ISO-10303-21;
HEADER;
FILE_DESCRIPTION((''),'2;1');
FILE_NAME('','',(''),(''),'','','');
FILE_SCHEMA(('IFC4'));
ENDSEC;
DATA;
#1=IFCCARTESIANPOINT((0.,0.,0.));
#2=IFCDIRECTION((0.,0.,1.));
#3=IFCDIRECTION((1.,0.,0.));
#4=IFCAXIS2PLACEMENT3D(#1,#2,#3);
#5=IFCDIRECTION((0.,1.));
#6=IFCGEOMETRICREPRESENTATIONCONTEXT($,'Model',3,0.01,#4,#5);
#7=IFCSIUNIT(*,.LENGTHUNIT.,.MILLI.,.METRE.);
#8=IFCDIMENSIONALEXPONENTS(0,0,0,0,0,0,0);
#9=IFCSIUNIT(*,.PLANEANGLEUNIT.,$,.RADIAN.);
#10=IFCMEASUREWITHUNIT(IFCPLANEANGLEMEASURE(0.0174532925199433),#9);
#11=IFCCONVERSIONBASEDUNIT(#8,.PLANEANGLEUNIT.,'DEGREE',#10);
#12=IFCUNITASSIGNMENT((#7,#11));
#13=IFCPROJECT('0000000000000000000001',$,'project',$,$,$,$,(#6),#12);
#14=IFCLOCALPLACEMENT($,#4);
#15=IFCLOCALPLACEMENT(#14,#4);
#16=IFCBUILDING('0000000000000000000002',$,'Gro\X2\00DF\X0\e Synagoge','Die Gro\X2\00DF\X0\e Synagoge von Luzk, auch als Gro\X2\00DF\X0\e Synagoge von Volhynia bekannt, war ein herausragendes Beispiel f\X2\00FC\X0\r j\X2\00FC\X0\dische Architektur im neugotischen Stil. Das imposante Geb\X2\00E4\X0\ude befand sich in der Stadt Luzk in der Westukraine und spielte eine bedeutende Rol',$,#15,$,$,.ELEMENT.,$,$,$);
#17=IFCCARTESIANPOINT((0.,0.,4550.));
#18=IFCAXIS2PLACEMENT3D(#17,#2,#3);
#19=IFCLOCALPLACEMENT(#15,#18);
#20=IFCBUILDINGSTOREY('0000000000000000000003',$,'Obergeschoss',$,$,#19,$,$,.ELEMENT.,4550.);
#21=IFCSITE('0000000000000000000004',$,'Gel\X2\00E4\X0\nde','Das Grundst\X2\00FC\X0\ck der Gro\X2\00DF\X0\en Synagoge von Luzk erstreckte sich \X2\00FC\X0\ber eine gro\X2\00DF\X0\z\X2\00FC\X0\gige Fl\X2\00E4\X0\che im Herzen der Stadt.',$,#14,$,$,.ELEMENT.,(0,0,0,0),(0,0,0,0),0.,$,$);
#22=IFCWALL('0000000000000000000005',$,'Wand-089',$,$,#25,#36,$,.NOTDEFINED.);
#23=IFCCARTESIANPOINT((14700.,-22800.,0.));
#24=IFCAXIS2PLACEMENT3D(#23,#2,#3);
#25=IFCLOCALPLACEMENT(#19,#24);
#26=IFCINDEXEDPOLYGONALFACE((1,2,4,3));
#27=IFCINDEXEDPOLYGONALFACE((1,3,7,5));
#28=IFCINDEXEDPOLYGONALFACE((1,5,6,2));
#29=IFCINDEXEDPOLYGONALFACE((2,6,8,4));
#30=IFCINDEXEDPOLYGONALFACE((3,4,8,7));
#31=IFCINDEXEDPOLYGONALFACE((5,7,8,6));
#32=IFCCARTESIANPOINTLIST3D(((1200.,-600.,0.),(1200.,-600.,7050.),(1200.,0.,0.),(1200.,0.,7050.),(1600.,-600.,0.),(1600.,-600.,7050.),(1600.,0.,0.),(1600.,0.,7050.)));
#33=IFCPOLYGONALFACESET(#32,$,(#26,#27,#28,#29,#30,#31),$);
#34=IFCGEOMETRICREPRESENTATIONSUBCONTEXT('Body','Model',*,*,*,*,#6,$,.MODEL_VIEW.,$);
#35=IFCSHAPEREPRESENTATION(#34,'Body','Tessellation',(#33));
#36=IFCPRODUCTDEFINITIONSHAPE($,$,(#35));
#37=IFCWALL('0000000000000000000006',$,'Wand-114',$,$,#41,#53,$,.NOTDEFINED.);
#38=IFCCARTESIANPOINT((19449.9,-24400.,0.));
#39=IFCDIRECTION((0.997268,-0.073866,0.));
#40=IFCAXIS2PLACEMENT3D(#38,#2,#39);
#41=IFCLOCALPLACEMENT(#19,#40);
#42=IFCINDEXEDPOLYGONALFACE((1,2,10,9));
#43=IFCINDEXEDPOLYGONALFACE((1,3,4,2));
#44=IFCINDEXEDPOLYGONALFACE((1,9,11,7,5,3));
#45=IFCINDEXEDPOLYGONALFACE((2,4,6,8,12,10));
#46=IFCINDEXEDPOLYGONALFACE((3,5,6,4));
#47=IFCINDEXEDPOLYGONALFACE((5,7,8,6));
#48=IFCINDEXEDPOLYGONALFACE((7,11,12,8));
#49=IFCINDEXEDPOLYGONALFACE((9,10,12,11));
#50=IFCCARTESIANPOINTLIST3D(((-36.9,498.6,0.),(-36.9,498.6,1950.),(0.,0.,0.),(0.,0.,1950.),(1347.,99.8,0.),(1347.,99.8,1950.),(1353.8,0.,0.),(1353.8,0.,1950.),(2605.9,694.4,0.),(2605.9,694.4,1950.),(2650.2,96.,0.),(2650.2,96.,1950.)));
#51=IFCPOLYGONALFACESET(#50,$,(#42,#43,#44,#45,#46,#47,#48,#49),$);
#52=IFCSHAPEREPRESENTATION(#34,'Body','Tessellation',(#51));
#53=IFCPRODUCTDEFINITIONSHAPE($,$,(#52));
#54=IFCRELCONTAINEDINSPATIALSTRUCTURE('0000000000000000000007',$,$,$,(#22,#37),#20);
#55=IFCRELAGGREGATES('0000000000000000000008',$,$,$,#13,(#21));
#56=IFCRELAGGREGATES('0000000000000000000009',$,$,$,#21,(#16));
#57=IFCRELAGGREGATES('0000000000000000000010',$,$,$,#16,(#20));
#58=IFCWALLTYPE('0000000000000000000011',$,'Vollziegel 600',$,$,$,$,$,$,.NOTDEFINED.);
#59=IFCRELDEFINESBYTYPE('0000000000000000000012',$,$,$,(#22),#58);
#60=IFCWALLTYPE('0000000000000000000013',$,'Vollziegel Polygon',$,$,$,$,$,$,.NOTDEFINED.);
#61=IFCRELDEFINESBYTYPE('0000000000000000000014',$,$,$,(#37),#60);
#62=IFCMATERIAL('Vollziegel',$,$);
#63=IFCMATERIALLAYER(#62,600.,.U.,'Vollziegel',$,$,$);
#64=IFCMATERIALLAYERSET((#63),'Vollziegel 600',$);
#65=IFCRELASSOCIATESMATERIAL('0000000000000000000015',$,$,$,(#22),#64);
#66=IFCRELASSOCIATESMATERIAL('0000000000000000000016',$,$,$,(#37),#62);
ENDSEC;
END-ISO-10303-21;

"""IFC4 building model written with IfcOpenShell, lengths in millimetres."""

from ifc_helpers import new_model, entity, si_unit, converted_unit, direction, frame, origin_with_axes, place, context, subcontext, project, spatial, line, indexed_curve, outline, extrude, material, layer, layer_set, layer_usage, type_object, element, save


model = new_model("IFC4")

# Units and contexts
model_context = context("Model", 3, precision=0.01, world=origin_with_axes(), true_north=direction((0.0, 1.0)))
body_context = subcontext(model_context, "Body", "Model", "MODEL_VIEW")
ifc_project = project(units=[si_unit("LENGTHUNIT", "METRE", prefix="MILLI"), converted_unit("PLANEANGLEUNIT", "DEGREE", entity("IfcPlaneAngleMeasure", 0.0174532925199433), si_unit("PLANEANGLEUNIT", "RADIAN"), dimensions=[0, 0, 0, 0, 0, 0, 0])], contexts=[model_context])

# Site, building, storey
site_placement = place(None, origin_with_axes())
site = spatial("IfcSite", under=ifc_project, at=site_placement, Name="Gelände", Description="Das Grundstück der Großen Synagoge von Luzk erstreckte sich über eine großzügige Fläche im Herzen der Stadt.", CompositionType="ELEMENT", RefLatitude=(0, 0, 0, 0), RefLongitude=(0, 0, 0, 0), RefElevation=0.0)
building_placement = place(site_placement, origin_with_axes())
building = spatial("IfcBuilding", under=site, at=building_placement, Name="Große Synagoge", Description="Die Große Synagoge von Luzk, auch als Große Synagoge von Volhynia bekannt, war ein herausragendes Beispiel für jüdische Architektur im neugotischen Stil. Das imposante Gebäude befand sich in der Stadt Luzk in der Westukraine und spielte eine bedeutende Rol", CompositionType="ELEMENT")
storey_placement = place(building_placement, frame((0.0, 0.0, 4550.0), z_axis=(0.0, 0.0, 1.0), x_axis=(1.0, 0.0, 0.0)))
storey = spatial("IfcBuildingStorey", under=building, at=storey_placement, Name="Obergeschoss", CompositionType="ELEMENT", Elevation=4550.0)

# Shared definitions
ifc_material_1 = material(Name="Vollziegel")

# Walls
ifc_layer_1 = layer(ifc_material_1, 600.0, ventilated="UNKNOWN", Name="Vollziegel")
ifc_layer_set_1 = layer_set([ifc_layer_1], Name="Vollziegel 600")
ifc_layer_usage_1 = layer_usage(ifc_layer_set_1, "AXIS2", "POSITIVE", -600.0)
wall_type_1 = type_object("IfcWallType", Name="Vollziegel 600", PredefinedType="NOTDEFINED")
wall_1_placement = place(storey_placement, frame((14700.0, -22800.0, 0.0), z_axis=(0.0, 0.0, 1.0), x_axis=(1.0, 0.0, 0.0)))
element("IfcWall", 1, at=wall_1_placement, inside=storey, type_object=wall_type_1, material=ifc_layer_usage_1, Name="Wand-089", PredefinedType="NOTDEFINED", context=body_context, shape_type="SweptSolid", body=[
    extrude(outline(indexed_curve([(1200.0, -600.0), (1600.0, -600.0), (1600.0, 0.0), (1200.0, 0.0)], segments=[line(1, 2, 3, 4, 1)])), origin_with_axes(), (0.0, 0.0, 1.0), 7050.0),
])
wall_type_2 = type_object("IfcWallType", Name="Vollziegel Polygon", PredefinedType="NOTDEFINED")
wall_2_placement = place(storey_placement, frame((19449.9, -24400.0, 0.0), z_axis=(0.0, 0.0, 1.0), x_axis=(0.997268, -0.073866, 0.0)))
element("IfcWall", 2, at=wall_2_placement, inside=storey, type_object=wall_type_2, material=ifc_material_1, Name="Wand-114", PredefinedType="NOTDEFINED", context=body_context, shape_type="SweptSolid", body=[
    extrude(outline(indexed_curve([(0.0, 0.0), (1347.0, 99.8), (1353.8, 0.0), (2650.2, 96.0), (2605.9, 694.4), (-36.9, 498.6)], segments=[line(1, 2, 3, 4, 5, 6, 1)])), origin_with_axes(), (0.0, 0.0, 1.0), 1950.0),
])

save(model, "model.ifc")
